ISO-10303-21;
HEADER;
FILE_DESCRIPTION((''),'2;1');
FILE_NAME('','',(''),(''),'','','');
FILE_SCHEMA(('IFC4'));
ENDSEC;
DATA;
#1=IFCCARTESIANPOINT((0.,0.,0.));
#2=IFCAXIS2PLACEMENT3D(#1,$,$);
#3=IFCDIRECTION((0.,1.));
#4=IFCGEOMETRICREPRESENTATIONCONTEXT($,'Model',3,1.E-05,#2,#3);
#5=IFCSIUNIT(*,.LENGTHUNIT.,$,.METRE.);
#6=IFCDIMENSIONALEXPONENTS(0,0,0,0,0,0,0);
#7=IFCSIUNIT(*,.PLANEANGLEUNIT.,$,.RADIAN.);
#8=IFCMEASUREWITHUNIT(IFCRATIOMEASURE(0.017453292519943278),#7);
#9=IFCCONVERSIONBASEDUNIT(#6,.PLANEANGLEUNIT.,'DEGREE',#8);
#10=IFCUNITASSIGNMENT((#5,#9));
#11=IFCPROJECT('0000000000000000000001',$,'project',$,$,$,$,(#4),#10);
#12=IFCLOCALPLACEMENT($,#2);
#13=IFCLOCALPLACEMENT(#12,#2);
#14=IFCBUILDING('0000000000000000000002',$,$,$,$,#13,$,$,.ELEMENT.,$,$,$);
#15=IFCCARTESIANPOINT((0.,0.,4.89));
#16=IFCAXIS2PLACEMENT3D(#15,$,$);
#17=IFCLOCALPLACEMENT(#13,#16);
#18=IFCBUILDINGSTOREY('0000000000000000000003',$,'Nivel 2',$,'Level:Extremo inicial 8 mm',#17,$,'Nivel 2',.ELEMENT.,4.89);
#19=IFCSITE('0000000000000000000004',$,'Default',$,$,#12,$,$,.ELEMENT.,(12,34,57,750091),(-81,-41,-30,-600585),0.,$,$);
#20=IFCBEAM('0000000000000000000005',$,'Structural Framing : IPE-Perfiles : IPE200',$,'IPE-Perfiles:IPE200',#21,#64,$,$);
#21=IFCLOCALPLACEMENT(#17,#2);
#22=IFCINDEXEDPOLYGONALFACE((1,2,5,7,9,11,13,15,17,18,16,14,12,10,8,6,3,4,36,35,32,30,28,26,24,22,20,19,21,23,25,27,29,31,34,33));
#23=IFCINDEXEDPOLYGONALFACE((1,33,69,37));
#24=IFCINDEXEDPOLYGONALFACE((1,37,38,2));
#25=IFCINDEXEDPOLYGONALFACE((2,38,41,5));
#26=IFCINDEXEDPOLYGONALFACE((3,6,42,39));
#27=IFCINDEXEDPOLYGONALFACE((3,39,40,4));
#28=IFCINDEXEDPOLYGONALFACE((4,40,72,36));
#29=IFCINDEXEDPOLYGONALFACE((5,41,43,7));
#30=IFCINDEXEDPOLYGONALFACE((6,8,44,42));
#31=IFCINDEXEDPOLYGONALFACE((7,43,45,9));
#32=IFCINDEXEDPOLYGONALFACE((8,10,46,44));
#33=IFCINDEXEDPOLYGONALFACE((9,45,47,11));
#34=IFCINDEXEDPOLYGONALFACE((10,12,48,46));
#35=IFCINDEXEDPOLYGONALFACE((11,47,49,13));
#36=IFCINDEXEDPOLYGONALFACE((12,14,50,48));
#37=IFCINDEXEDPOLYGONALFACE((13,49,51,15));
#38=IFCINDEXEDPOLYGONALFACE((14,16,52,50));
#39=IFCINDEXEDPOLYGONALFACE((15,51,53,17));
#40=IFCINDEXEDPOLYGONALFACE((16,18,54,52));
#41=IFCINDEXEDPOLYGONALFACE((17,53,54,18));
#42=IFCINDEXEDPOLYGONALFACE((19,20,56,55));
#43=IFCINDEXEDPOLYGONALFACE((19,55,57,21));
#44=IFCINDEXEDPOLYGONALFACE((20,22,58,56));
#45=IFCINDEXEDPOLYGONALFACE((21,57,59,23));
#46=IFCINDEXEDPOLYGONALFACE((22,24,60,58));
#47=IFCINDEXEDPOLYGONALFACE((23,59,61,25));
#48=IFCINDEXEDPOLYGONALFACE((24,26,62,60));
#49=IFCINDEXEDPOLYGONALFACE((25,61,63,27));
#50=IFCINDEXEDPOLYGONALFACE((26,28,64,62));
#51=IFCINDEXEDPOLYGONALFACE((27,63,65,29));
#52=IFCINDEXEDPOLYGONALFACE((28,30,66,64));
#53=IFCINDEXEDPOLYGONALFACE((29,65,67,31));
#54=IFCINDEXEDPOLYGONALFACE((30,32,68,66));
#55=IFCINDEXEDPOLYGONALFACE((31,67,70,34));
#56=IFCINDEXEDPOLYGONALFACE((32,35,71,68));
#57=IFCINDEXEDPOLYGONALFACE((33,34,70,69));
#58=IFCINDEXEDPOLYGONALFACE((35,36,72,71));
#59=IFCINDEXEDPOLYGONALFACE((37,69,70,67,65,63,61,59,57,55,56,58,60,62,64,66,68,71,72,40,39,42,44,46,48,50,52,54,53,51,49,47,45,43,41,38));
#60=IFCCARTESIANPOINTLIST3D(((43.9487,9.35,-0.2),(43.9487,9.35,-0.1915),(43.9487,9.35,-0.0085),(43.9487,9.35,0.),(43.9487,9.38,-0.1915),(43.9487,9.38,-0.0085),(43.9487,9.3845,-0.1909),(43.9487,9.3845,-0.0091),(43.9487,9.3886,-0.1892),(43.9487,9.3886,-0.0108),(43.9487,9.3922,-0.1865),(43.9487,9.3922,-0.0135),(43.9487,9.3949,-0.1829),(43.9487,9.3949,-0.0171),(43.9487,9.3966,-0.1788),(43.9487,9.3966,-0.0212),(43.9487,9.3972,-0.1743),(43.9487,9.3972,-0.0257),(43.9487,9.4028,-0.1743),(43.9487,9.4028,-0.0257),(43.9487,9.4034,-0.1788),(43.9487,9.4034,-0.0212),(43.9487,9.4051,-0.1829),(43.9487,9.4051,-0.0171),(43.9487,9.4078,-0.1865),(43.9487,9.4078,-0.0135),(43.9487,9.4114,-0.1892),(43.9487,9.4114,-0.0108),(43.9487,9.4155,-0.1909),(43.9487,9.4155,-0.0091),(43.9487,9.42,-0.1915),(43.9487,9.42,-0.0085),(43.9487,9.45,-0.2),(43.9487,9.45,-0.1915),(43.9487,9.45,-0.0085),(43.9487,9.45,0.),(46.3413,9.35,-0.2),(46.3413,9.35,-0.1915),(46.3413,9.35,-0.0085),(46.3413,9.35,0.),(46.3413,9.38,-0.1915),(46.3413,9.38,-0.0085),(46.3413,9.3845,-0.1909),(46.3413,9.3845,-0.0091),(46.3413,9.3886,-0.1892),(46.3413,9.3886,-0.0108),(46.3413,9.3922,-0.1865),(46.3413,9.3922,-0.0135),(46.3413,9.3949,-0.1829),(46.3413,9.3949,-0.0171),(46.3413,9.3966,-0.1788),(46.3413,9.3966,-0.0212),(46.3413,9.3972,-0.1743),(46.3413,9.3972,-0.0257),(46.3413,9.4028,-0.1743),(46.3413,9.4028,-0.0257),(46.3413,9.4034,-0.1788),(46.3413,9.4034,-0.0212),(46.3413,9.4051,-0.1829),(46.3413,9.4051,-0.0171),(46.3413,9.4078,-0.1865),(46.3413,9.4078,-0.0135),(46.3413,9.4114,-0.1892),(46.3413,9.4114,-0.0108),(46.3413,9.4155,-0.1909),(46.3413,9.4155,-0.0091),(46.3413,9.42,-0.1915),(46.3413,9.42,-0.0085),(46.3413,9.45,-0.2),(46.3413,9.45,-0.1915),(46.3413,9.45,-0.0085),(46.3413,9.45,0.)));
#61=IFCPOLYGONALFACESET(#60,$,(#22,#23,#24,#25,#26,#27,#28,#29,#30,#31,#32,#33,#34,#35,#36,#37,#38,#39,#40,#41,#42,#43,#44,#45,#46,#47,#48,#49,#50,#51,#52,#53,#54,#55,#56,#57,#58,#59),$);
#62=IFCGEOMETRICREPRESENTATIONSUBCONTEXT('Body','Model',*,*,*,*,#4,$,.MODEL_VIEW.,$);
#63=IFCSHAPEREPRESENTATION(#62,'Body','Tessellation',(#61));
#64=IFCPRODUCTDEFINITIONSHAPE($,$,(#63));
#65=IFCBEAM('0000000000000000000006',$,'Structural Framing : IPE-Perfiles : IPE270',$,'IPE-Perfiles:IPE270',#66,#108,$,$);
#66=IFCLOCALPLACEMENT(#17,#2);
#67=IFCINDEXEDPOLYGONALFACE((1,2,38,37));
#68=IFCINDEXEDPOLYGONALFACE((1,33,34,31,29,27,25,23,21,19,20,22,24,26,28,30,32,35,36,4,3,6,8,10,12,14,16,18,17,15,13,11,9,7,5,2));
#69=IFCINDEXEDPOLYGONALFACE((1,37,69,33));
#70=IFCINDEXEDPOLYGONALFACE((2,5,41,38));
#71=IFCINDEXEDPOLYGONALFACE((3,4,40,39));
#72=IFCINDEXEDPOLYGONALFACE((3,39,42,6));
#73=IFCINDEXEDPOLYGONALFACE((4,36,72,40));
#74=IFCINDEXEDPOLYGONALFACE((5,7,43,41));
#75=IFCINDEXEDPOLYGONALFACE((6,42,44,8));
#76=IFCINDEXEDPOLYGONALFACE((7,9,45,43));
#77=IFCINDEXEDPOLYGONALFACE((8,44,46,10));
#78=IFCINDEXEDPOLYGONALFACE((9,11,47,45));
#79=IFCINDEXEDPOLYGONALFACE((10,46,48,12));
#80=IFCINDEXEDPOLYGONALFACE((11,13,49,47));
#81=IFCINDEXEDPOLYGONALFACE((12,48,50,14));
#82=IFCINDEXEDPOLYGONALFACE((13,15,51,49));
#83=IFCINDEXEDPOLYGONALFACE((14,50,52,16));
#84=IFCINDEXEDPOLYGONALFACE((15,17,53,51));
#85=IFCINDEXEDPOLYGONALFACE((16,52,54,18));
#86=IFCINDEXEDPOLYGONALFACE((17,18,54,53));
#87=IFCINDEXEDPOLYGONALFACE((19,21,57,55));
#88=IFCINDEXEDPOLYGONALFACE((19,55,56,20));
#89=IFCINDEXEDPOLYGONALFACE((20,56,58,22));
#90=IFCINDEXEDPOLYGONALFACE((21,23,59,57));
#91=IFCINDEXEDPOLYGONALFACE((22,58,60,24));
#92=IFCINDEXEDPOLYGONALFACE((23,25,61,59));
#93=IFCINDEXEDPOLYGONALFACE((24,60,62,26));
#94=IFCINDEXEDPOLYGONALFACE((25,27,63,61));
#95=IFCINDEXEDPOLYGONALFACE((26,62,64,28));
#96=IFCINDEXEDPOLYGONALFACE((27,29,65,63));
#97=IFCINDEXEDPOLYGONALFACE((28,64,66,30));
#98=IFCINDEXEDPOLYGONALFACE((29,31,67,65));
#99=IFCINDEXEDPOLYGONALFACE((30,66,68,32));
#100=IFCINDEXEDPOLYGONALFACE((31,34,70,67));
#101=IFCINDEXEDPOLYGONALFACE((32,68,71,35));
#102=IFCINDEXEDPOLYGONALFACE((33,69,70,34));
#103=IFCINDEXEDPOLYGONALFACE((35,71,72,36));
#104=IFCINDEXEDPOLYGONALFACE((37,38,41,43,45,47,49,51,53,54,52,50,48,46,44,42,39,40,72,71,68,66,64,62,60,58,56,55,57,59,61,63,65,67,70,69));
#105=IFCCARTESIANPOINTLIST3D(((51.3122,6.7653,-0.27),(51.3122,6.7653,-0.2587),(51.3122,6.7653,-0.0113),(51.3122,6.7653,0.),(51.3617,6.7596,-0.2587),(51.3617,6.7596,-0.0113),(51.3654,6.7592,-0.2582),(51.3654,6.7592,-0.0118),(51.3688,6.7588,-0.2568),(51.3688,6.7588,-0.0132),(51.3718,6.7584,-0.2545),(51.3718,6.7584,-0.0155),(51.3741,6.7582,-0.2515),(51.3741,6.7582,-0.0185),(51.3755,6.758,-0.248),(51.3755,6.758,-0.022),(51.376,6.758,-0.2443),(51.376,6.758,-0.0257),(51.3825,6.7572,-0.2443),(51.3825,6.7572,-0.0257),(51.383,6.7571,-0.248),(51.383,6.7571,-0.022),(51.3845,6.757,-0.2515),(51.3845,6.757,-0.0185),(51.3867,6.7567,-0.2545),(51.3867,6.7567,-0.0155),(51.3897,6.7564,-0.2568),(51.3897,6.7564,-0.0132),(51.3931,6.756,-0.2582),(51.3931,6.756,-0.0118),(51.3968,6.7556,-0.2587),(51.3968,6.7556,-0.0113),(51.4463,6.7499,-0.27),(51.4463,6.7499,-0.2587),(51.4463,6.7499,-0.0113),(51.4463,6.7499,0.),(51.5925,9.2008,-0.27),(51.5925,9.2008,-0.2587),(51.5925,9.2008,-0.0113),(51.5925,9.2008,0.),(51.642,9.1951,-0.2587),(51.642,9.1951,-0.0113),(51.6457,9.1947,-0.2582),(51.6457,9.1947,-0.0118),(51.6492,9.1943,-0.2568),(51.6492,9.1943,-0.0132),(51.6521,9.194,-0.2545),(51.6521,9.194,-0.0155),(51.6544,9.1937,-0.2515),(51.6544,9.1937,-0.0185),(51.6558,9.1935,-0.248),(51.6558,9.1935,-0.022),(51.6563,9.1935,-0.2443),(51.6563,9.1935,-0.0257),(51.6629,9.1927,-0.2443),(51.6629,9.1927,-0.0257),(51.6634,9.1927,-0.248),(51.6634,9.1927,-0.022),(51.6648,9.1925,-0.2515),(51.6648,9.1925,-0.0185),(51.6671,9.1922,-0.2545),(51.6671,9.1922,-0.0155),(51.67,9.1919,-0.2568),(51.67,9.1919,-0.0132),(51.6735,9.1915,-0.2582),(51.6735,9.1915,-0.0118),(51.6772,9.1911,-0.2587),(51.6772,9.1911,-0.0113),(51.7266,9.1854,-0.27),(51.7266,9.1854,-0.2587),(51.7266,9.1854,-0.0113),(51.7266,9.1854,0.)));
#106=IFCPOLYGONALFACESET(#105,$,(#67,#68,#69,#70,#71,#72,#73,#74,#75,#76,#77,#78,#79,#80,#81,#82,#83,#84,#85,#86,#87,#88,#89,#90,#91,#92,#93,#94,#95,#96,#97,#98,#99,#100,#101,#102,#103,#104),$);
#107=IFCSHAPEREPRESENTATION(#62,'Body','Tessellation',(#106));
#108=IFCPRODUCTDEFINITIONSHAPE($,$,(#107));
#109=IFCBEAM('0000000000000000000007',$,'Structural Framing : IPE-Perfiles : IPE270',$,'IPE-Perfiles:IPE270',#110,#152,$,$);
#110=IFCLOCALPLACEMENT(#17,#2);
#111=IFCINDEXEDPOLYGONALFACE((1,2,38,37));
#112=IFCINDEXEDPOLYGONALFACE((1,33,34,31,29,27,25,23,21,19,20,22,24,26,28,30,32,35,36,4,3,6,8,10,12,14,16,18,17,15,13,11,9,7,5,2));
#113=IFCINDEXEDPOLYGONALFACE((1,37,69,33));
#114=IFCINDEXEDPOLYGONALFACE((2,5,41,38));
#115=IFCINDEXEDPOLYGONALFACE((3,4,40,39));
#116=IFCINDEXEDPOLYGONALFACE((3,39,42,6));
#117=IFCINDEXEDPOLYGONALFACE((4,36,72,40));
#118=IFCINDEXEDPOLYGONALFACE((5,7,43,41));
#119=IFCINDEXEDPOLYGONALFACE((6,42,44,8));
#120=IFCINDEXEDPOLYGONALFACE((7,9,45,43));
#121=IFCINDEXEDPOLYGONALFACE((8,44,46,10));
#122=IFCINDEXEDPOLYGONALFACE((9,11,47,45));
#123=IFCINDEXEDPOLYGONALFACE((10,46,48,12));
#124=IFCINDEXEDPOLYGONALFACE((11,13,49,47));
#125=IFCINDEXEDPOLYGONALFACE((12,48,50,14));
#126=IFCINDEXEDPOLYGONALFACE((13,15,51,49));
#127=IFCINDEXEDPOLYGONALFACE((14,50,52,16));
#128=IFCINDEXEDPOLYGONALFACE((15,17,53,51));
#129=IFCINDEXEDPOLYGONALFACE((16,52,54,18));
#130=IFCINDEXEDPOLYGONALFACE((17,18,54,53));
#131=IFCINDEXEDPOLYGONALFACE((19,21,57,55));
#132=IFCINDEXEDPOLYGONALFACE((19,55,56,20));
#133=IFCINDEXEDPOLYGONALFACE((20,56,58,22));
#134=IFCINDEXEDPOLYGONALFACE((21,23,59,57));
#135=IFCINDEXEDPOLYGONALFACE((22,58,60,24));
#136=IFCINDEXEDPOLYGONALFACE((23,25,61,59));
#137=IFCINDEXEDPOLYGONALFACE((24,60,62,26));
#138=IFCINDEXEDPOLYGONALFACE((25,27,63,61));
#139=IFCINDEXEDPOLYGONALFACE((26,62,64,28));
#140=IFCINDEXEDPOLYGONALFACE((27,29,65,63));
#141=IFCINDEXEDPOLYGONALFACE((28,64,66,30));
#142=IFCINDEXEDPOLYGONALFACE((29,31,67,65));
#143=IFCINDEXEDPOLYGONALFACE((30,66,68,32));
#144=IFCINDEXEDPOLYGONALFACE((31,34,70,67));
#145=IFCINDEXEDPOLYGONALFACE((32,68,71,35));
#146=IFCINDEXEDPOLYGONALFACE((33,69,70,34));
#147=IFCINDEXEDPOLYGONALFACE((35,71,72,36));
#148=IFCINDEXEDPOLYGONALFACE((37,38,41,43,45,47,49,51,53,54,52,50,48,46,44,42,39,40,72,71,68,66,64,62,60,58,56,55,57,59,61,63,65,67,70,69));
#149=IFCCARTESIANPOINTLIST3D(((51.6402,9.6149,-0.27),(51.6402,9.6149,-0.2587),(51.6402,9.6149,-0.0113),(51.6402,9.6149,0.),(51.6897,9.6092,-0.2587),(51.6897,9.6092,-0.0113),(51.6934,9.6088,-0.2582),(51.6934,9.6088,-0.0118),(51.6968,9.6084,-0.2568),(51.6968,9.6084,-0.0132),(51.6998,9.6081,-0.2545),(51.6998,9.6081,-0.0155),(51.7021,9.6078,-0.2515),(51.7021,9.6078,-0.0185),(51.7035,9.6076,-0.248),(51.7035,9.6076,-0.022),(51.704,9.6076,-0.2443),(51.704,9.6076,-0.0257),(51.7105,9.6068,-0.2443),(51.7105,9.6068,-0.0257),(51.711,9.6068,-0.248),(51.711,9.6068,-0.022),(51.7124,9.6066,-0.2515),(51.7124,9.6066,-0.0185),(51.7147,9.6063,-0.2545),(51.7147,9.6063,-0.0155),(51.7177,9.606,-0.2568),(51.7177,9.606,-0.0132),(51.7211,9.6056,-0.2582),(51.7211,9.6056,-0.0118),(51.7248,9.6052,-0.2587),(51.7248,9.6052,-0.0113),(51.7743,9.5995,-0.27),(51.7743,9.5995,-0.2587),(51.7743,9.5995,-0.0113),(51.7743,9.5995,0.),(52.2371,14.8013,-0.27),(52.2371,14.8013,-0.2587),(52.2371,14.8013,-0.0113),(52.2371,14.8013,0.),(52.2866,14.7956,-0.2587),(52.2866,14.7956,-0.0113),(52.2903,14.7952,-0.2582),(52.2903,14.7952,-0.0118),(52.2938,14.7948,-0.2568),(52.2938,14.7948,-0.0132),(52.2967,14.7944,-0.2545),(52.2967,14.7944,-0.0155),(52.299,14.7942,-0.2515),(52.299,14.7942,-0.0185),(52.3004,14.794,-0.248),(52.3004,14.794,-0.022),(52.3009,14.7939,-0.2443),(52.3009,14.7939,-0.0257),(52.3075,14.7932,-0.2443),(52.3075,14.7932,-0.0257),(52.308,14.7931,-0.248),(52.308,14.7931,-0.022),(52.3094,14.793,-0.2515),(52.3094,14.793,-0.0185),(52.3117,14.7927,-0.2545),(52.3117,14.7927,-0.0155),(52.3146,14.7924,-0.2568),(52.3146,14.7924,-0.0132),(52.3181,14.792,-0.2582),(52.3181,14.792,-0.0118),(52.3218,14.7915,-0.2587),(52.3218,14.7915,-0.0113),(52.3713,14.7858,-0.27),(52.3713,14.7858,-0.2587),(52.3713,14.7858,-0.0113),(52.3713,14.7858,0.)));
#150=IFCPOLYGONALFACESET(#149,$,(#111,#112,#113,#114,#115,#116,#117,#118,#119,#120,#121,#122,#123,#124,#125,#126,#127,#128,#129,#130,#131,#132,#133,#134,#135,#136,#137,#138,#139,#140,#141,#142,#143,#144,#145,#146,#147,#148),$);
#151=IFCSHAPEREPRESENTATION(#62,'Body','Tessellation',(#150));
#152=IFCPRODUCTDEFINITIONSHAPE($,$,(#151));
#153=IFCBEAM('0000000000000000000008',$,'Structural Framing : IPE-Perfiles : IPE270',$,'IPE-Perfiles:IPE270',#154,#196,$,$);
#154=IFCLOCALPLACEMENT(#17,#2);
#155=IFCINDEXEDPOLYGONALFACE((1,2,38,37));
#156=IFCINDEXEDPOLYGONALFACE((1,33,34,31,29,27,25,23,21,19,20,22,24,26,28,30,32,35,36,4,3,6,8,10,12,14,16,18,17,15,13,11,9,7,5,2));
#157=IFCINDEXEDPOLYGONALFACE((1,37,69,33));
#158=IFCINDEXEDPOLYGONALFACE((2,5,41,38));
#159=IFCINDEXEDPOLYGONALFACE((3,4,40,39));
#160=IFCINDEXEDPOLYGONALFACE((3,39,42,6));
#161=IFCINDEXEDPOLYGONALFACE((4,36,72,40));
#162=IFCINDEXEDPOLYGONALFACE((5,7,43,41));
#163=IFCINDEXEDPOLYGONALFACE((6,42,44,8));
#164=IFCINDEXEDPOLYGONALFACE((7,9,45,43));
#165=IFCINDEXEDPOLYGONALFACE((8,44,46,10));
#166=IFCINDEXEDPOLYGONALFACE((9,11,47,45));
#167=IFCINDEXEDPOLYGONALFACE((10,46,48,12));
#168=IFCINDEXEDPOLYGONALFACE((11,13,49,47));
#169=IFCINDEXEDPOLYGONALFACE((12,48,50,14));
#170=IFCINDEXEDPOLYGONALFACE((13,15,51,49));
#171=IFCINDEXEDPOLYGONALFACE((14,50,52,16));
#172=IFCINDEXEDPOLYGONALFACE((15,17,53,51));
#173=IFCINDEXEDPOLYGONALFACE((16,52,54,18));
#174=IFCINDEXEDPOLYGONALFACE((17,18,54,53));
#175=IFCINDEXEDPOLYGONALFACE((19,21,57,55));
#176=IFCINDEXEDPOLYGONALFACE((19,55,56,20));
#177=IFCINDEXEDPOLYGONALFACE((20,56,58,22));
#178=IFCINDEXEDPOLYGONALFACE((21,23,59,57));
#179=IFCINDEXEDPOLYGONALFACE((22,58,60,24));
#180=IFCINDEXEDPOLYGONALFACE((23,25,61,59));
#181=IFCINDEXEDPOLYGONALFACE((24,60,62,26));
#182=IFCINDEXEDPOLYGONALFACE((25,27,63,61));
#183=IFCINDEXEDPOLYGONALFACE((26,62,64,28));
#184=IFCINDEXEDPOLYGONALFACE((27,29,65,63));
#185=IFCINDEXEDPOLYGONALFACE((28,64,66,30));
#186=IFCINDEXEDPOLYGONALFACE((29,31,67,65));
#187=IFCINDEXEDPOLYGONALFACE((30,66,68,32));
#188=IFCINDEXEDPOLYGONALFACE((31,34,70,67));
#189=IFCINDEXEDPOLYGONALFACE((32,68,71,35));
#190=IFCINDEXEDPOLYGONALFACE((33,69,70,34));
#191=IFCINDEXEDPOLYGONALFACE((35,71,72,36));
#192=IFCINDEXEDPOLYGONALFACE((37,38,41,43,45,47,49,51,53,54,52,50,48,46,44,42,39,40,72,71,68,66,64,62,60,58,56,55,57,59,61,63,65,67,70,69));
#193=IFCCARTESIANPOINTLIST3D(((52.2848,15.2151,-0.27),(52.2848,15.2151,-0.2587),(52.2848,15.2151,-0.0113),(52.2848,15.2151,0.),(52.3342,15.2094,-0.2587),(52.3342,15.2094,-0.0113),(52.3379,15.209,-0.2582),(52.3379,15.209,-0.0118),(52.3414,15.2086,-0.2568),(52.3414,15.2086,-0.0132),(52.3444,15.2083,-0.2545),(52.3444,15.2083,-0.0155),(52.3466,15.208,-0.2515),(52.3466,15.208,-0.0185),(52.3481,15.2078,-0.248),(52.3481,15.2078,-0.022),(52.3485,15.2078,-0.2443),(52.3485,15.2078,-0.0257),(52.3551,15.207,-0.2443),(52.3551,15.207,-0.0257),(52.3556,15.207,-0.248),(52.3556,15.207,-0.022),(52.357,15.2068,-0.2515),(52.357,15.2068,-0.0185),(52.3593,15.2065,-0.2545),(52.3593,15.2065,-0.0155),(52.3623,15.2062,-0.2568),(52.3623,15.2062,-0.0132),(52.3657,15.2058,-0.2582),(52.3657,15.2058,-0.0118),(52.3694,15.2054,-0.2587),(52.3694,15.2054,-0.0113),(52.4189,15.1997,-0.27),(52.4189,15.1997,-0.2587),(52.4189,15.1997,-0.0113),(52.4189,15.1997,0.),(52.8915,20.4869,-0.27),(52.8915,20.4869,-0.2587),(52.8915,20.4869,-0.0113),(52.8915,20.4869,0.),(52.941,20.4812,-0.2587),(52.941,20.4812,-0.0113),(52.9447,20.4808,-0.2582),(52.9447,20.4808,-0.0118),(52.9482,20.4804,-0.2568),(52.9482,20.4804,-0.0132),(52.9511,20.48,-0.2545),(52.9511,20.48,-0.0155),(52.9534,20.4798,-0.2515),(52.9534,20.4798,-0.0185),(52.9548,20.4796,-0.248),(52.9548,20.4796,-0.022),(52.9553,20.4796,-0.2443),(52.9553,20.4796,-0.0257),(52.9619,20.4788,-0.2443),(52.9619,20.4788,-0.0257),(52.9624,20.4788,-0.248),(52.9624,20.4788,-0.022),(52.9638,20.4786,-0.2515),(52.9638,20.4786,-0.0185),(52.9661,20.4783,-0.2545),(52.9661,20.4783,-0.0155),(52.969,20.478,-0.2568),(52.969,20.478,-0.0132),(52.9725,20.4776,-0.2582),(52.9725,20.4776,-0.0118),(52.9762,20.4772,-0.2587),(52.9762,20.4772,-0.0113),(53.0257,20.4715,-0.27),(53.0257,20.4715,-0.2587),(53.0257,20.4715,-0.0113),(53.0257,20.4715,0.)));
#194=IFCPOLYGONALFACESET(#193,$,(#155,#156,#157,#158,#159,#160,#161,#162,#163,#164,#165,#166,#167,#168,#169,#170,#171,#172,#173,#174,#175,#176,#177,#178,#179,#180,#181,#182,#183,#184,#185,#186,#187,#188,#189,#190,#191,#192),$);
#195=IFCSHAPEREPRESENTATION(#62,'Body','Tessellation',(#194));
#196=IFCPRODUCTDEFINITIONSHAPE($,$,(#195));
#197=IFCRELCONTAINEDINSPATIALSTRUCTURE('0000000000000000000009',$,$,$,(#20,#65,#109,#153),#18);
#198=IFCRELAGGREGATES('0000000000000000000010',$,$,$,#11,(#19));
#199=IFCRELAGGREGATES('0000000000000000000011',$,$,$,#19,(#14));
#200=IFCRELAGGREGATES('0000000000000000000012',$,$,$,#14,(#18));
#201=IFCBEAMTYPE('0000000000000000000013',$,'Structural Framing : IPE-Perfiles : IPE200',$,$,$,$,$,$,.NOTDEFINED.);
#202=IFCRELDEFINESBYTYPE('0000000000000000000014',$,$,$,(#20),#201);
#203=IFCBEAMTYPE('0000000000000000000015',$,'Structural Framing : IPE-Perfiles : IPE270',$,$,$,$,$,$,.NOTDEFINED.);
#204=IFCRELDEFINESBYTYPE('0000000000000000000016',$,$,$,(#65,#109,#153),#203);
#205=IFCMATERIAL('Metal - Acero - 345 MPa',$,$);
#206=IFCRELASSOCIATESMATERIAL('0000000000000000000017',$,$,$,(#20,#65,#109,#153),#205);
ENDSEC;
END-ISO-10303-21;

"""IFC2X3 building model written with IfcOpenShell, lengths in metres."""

from ifc_helpers import new_model, entity, si_unit, converted_unit, direction, frame, frame_2d, origin, place, context, subcontext, project, spatial, i_section, extrude, material, type_object, element, save


model = new_model("IFC2X3")

# Units and contexts
model_context = context("Model", 3, precision=1e-05, world=origin(), true_north=direction((0.0, 1.0)))
body_context = subcontext(model_context, "Body", "Model", "MODEL_VIEW")
ifc_project = project(units=[si_unit("LENGTHUNIT", "METRE"), converted_unit("PLANEANGLEUNIT", "DEGREE", entity("IfcRatioMeasure", 0.017453292519943278), si_unit("PLANEANGLEUNIT", "RADIAN"), dimensions=[0, 0, 0, 0, 0, 0, 0])], contexts=[model_context])

# Site, building, storey
site_placement = place(None, origin())
site = spatial("IfcSite", under=ifc_project, at=site_placement, Name="Default", CompositionType="ELEMENT", RefLatitude=(12, 34, 57, 750091), RefLongitude=(-81, -41, -30, -600585), RefElevation=0.0)
building_placement = place(site_placement, origin())
building = spatial("IfcBuilding", under=site, at=building_placement, CompositionType="ELEMENT")
storey_placement = place(building_placement, frame((0.0, 0.0, 4.89)))
storey = spatial("IfcBuildingStorey", under=building, at=storey_placement, Name="Nivel 2", ObjectType="Level:Extremo inicial 8 mm", LongName="Nivel 2", CompositionType="ELEMENT", Elevation=4.89)

# Shared definitions
ifc_material_1 = material(Name="Metal - Acero - 345 MPa")

# Beams
beam_type_1 = type_object("IfcBeamType", Name="Structural Framing : IPE-Perfiles : IPE200", PredefinedType="NOTDEFINED")
beam_1_placement = place(storey_placement, frame((43.935, 9.4, 0.0)))
element("IfcBeam", 1, at=beam_1_placement, inside=storey, type_object=beam_type_1, material=ifc_material_1, Name="Structural Framing : IPE-Perfiles : IPE200", ObjectType="IPE-Perfiles:IPE200", context=body_context, shape_type="SweptSolid", body=[
    extrude(i_section(OverallWidth=0.1, OverallDepth=0.2, WebThickness=0.0056, FlangeThickness=0.0085, FilletRadius=0.0172, at=frame_2d((0.0, 0.0), x_axis=(0.0, 1.0))), frame((0.0137, 0.0, -0.1), z_axis=(1.0, 0.0, 0.0), x_axis=(0.0, 0.0, -1.0)), (0.0, 0.0, 1.0), 2.3926),
])
beam_type_2 = type_object("IfcBeamType", Name="Structural Framing : IPE-Perfiles : IPE270", PredefinedType="NOTDEFINED")
beam_2_placement = place(storey_placement, frame((51.3776, 6.7435, 0.0), z_axis=(0.0, 0.0, 1.0), x_axis=(0.114344, 0.993441, 0.0)))
element("IfcBeam", 2, at=beam_2_placement, inside=storey, type_object=beam_type_2, material=ifc_material_1, Name="Structural Framing : IPE-Perfiles : IPE270", ObjectType="IPE-Perfiles:IPE270", context=body_context, shape_type="SweptSolid", body=[
    extrude(i_section(OverallWidth=0.135, OverallDepth=0.27, WebThickness=0.0066, FlangeThickness=0.0113, FilletRadius=0.0144, at=frame_2d((0.0, 0.0), x_axis=(0.0, 1.0))), frame((0.0141, 0.0, -0.135), z_axis=(1.0, 0.0, 0.0), x_axis=(0.0, 0.0, -1.0)), (0.0, 0.0, 1.0), 2.4516),
])
beam_3_placement = place(storey_placement, frame((51.7057, 9.5935, 0.0), z_axis=(0.0, 0.0, 1.0), x_axis=(0.114344, 0.993441, 0.0)))
element("IfcBeam", 3, at=beam_3_placement, inside=storey, type_object=beam_type_2, material=ifc_material_1, Name="Structural Framing : IPE-Perfiles : IPE270", ObjectType="IPE-Perfiles:IPE270", context=body_context, shape_type="SweptSolid", body=[
    extrude(i_section(OverallWidth=0.135, OverallDepth=0.27, WebThickness=0.0066, FlangeThickness=0.0113, FilletRadius=0.0144, at=frame_2d((0.0, 0.0), x_axis=(0.0, 1.0))), frame((0.0137, 0.0, -0.135), z_axis=(1.0, 0.0, 0.0), x_axis=(0.0, 0.0, -1.0)), (0.0, 0.0, 1.0), 5.2206),
])
beam_4_placement = place(storey_placement, frame((52.3502, 15.1935, 0.0), z_axis=(0.0, 0.0, 1.0), x_axis=(0.114344, 0.993441, 0.0)))
element("IfcBeam", 4, at=beam_4_placement, inside=storey, type_object=beam_type_2, material=ifc_material_1, Name="Structural Framing : IPE-Perfiles : IPE270", ObjectType="IPE-Perfiles:IPE270", context=body_context, shape_type="SweptSolid", body=[
    extrude(i_section(OverallWidth=0.135, OverallDepth=0.27, WebThickness=0.0066, FlangeThickness=0.0113, FilletRadius=0.0144, at=frame_2d((0.0, 0.0), x_axis=(0.0, 1.0))), frame((0.0139, 0.0, -0.135), z_axis=(1.0, 0.0, 0.0), x_axis=(0.0, 0.0, -1.0)), (0.0, 0.0, 1.0), 5.3066),
])

save(model, "model.ifc")
